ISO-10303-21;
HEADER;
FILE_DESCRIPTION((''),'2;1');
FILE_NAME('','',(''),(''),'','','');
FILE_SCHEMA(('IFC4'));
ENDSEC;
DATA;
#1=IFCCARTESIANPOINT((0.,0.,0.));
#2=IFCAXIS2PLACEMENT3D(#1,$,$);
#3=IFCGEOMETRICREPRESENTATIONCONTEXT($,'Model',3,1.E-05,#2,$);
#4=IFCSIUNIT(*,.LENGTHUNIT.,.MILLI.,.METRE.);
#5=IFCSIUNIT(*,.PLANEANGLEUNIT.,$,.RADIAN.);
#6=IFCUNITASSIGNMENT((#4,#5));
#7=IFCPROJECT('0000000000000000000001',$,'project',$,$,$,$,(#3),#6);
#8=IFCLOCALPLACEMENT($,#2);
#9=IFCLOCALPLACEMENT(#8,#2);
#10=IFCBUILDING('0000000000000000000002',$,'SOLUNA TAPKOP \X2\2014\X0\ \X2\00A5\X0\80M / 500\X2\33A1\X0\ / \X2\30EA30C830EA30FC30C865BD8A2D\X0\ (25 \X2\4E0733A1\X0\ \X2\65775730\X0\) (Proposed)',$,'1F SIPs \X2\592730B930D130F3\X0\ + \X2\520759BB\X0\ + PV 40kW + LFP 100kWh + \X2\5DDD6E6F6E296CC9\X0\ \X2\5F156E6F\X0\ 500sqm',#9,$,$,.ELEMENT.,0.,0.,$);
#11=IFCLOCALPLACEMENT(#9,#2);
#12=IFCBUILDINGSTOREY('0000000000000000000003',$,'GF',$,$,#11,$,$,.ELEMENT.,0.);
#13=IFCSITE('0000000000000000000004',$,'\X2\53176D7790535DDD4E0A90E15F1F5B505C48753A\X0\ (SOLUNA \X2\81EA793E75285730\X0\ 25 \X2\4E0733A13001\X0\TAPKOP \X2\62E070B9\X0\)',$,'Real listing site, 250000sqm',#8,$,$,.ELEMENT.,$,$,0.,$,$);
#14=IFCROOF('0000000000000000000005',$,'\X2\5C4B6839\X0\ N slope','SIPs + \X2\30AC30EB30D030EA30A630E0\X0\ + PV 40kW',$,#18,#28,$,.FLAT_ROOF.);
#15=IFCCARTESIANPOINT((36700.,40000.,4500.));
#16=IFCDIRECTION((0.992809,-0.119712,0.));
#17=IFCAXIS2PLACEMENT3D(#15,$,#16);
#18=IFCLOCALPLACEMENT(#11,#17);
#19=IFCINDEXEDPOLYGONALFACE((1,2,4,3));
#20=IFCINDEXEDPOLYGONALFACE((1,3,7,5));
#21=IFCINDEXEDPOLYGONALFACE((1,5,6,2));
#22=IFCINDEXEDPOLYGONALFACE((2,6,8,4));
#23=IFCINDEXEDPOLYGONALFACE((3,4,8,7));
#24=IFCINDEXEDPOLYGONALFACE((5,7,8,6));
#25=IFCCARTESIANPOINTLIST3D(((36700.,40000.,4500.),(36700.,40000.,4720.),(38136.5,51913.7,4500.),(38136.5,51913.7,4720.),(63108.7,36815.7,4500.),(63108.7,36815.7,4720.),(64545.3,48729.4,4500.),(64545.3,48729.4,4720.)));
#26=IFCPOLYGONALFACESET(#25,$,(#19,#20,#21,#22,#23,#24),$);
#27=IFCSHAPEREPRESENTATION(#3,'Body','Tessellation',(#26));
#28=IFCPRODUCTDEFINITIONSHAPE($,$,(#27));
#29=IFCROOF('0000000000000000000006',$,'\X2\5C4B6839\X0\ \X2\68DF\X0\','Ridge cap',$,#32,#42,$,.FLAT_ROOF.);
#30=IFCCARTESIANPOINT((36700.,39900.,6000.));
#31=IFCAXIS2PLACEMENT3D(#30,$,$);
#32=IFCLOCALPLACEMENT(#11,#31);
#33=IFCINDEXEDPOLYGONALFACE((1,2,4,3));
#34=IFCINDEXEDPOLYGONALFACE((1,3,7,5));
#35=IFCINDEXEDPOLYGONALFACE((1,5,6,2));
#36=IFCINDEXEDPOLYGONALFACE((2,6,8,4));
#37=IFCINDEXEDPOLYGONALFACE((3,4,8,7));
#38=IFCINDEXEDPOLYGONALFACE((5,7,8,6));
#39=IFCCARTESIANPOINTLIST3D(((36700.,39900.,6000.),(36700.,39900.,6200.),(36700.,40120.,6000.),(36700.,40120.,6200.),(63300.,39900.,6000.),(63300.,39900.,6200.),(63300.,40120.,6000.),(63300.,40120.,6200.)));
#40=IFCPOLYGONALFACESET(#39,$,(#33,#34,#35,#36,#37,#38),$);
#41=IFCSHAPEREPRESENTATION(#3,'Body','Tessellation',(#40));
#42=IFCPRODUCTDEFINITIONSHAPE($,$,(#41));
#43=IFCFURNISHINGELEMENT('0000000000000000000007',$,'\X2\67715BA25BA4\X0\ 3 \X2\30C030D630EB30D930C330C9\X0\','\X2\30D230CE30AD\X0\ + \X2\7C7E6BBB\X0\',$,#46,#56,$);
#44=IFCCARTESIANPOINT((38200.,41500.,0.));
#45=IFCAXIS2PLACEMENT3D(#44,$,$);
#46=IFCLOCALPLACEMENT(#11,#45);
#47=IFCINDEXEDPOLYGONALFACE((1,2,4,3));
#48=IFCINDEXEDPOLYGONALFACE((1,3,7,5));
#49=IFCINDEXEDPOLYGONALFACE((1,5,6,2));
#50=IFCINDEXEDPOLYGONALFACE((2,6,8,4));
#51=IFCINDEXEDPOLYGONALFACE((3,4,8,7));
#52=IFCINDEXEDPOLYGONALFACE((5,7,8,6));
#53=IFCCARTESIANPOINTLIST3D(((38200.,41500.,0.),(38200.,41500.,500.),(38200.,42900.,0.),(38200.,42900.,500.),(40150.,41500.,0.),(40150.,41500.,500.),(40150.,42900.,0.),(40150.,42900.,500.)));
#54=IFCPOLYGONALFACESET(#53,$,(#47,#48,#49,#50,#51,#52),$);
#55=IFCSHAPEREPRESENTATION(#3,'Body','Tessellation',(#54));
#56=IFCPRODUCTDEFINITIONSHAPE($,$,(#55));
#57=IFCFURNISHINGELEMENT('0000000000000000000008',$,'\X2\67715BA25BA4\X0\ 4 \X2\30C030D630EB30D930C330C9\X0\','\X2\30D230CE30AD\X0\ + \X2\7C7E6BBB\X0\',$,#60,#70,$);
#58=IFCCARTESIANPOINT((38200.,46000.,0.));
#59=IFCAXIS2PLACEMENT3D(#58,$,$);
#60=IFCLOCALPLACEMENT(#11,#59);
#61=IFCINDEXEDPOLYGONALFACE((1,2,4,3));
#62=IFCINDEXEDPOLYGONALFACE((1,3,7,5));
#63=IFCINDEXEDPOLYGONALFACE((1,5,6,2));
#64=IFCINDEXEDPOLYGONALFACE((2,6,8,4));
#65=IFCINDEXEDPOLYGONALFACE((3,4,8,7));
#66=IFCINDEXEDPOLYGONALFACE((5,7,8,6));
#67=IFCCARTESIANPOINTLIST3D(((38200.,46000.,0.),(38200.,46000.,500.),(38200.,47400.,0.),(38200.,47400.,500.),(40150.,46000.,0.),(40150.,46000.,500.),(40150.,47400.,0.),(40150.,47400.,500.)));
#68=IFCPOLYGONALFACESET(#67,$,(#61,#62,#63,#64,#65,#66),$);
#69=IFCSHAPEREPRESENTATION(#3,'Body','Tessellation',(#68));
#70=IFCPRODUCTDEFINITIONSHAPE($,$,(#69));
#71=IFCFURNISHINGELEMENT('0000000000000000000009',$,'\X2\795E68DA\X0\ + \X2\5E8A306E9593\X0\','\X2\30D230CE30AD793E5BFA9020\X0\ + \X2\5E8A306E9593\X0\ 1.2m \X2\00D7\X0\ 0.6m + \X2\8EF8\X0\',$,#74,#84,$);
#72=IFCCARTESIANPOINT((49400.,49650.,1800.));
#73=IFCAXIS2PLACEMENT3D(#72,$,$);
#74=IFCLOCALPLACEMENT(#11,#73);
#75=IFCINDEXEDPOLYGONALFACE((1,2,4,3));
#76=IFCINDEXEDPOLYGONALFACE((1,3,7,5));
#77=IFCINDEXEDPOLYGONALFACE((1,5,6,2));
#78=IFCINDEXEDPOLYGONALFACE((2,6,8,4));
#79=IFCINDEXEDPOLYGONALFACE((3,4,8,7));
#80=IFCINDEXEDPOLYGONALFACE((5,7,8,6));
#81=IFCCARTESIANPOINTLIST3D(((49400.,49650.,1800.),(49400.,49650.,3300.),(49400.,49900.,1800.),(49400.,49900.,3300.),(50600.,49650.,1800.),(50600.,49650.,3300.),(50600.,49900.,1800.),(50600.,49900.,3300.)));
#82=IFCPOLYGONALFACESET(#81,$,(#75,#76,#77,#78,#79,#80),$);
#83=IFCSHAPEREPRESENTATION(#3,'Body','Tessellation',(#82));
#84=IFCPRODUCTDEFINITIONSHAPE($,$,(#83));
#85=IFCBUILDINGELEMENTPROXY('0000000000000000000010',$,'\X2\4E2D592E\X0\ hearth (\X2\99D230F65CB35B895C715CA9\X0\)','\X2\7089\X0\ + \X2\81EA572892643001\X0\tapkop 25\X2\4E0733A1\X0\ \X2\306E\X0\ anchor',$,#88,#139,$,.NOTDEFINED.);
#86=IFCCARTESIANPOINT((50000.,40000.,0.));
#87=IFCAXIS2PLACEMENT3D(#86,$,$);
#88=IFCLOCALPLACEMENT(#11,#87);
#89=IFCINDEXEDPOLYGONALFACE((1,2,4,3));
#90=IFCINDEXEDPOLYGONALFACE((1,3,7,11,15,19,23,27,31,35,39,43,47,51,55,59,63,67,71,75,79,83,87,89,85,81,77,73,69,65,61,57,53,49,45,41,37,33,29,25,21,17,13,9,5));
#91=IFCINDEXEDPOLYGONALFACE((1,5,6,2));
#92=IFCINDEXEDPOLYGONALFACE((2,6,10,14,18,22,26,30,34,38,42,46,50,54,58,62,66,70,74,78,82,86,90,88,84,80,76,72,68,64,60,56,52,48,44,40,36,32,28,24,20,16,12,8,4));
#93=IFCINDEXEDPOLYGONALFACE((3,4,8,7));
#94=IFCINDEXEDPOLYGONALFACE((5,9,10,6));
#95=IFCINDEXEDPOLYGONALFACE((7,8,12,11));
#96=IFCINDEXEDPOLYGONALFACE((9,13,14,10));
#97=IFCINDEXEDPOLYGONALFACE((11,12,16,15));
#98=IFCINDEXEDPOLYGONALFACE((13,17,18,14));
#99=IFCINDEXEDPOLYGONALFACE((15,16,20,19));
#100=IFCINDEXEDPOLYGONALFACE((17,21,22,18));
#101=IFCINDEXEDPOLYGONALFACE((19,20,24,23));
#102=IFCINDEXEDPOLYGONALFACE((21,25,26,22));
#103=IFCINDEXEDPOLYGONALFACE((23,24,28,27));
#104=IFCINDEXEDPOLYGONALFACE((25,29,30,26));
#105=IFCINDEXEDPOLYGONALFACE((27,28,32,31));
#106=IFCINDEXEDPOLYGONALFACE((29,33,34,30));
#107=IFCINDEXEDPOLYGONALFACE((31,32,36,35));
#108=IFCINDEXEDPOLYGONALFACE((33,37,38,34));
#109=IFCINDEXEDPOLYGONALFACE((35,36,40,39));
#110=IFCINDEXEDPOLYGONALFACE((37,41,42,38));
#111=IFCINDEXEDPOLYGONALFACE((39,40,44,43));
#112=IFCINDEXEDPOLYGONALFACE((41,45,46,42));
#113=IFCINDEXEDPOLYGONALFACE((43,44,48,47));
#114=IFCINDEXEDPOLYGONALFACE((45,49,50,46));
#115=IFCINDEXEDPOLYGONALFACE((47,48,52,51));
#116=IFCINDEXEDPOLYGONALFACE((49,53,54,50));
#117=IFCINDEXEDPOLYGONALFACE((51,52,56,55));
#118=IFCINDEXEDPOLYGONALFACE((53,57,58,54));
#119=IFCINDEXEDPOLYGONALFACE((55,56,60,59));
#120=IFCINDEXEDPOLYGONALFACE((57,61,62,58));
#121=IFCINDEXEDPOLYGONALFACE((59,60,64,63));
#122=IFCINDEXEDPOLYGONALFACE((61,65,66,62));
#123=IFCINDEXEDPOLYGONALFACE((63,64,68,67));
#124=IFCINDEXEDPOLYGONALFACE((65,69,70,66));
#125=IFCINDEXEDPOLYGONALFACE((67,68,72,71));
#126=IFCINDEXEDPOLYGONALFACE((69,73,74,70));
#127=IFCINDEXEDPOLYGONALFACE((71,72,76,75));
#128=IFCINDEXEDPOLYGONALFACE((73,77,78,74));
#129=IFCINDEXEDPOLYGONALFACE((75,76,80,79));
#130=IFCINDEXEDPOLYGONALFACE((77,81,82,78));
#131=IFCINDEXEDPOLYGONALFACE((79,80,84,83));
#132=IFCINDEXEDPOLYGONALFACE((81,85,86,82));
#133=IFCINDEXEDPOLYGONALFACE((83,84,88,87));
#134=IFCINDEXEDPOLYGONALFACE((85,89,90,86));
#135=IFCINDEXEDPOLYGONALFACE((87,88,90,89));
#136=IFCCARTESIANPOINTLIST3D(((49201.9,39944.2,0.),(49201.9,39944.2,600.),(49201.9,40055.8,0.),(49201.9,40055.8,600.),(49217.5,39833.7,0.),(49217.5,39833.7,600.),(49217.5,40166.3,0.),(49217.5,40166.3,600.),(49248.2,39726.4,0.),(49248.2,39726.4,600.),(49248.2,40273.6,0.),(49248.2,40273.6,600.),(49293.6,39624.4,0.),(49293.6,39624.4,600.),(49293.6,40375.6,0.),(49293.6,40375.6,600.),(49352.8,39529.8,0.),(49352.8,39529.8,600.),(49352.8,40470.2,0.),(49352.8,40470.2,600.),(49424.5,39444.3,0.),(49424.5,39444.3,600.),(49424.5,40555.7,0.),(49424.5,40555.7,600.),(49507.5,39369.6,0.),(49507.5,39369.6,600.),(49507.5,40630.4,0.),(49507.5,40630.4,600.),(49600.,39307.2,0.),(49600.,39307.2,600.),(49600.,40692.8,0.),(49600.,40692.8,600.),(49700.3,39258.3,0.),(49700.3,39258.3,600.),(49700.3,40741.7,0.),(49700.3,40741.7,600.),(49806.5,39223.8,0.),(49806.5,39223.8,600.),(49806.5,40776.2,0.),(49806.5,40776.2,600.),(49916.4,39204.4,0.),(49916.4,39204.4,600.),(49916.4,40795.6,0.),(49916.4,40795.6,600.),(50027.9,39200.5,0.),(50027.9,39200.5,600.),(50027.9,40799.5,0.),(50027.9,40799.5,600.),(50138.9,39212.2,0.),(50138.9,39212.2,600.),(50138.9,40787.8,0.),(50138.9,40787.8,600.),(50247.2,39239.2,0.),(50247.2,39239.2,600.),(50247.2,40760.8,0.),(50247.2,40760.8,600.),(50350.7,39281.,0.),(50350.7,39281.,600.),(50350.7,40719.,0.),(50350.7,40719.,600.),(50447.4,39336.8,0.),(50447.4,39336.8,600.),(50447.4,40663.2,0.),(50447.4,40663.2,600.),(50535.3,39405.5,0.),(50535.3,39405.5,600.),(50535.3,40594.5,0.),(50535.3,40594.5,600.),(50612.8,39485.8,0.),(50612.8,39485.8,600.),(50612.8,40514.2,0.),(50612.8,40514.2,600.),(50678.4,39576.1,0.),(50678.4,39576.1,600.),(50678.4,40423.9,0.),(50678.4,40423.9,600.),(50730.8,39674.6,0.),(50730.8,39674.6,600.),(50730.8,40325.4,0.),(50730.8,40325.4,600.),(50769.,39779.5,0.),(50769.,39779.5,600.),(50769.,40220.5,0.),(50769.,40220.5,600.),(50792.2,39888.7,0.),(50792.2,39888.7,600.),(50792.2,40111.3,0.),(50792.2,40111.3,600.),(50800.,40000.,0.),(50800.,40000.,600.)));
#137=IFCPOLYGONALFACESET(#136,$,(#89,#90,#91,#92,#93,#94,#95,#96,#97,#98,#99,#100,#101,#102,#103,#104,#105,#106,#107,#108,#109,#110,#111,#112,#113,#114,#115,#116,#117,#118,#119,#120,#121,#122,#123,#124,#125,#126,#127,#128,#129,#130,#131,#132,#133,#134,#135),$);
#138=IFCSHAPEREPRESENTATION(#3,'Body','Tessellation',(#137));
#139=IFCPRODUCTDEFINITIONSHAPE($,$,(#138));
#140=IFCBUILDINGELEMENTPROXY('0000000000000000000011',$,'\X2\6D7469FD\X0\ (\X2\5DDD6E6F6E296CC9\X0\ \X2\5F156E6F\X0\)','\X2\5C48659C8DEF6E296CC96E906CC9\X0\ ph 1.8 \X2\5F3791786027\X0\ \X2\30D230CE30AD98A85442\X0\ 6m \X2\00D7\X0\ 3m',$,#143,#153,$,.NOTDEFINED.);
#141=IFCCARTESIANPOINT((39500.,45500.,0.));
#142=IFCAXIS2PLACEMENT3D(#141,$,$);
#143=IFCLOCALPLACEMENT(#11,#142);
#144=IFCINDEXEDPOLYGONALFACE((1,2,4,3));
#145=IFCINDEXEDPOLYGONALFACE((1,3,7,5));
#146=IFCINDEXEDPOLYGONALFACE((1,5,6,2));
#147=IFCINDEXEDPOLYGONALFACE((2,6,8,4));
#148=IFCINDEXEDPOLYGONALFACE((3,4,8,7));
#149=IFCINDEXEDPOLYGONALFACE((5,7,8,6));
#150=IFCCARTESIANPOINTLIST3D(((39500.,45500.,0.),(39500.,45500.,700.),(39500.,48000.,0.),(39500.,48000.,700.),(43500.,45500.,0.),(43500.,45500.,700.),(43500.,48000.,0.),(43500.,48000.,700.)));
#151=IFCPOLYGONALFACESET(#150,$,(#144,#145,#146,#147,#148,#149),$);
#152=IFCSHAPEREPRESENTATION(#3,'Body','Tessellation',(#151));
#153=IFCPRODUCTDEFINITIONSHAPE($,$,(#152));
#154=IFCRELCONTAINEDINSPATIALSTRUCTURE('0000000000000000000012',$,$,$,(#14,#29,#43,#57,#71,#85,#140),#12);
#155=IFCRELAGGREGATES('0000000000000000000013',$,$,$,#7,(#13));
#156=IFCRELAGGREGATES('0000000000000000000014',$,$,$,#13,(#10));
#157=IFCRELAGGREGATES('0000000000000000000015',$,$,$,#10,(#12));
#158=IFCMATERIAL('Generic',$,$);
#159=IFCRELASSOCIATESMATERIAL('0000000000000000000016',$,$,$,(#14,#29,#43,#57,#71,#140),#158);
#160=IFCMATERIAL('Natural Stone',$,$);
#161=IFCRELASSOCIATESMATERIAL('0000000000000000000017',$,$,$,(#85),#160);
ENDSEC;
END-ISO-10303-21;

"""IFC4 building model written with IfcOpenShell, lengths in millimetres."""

from ifc_helpers import new_model, si_unit, frame, frame_2d, origin, origin_2d, place, context, project, spatial, rectangle, circle, extrude, material, element, save


model = new_model("IFC4")

# Units and contexts
model_context = context("Model", 3, precision=1e-05, world=origin())
ifc_project = project(units=[si_unit("LENGTHUNIT", "METRE", prefix="MILLI"), si_unit("PLANEANGLEUNIT", "RADIAN")], contexts=[model_context])

# Site, building, storey
site_placement = place(None, origin())
site = spatial("IfcSite", under=ifc_project, at=site_placement, Name="北海道川上郡弟子屈町 (SOLUNA 自社用地 25 万㎡、TAPKOP 拠点)", ObjectType="Real listing site, 250000sqm", CompositionType="ELEMENT", RefElevation=0.0)
building_placement = place(site_placement, origin())
building = spatial("IfcBuilding", under=site, at=building_placement, Name="SOLUNA TAPKOP — ¥80M / 500㎡ / リトリート施設 (25 万㎡ 敷地) (Proposed)", ObjectType="1F SIPs 大スパン + 切妻 + PV 40kW + LFP 100kWh + 川湯温泉 引湯 500sqm", CompositionType="ELEMENT", ElevationOfRefHeight=0.0, ElevationOfTerrain=0.0)
storey_placement = place(building_placement, origin())
storey = spatial("IfcBuildingStorey", under=building, at=storey_placement, Name="GF", CompositionType="ELEMENT", Elevation=0.0)

# Shared definitions
ifc_material_1 = material(Name="Generic")

# Roofs
roof_1_placement = place(storey_placement, frame((36700.0, 40000.0, 4500.0), x_axis=(0.992809, -0.119712, 0.0)))
element("IfcRoof", 1, at=roof_1_placement, inside=storey, material=ifc_material_1, Name="屋根 N slope", Description="SIPs + ガルバリウム + PV 40kW", PredefinedType="FLAT_ROOF", context=model_context, shape_type="SweptSolid", body=[
    extrude(rectangle(XDim=26600.0, YDim=12000.0, at=frame_2d((13300.0, 6000.0))), frame((36700.0, 40000.0, 4500.0), x_axis=(0.992809, -0.119712, 0.0)), (0.0, 0.0, 1.0), 220.0),
])
roof_2_placement = place(storey_placement, frame((36700.0, 39900.0, 6000.0)))
element("IfcRoof", 2, at=roof_2_placement, inside=storey, material=ifc_material_1, Name="屋根 棟", Description="Ridge cap", PredefinedType="FLAT_ROOF", context=model_context, shape_type="SweptSolid", body=[
    extrude(rectangle(XDim=26600.0, YDim=220.0, at=frame_2d((13300.0, 110.0))), frame((36700.0, 39900.0, 6000.0)), (0.0, 0.0, 1.0), 200.0),
])

# Furnishing elements
furnishing_1_placement = place(storey_placement, frame((38200.0, 41500.0, 0.0)))
element("IfcFurnishingElement", 3, at=furnishing_1_placement, inside=storey, material=ifc_material_1, Name="東客室 3 ダブルベッド", Description="ヒノキ + 籾殻", context=model_context, shape_type="SweptSolid", body=[
    extrude(rectangle(XDim=1950.0, YDim=1400.0, at=frame_2d((975.0, 700.0))), frame((38200.0, 41500.0, 0.0)), (0.0, 0.0, 1.0), 500.0),
])
furnishing_2_placement = place(storey_placement, frame((38200.0, 46000.0, 0.0)))
element("IfcFurnishingElement", 4, at=furnishing_2_placement, inside=storey, material=ifc_material_1, Name="東客室 4 ダブルベッド", Description="ヒノキ + 籾殻", context=model_context, shape_type="SweptSolid", body=[
    extrude(rectangle(XDim=1950.0, YDim=1400.0, at=frame_2d((975.0, 700.0))), frame((38200.0, 46000.0, 0.0)), (0.0, 0.0, 1.0), 500.0),
])
furnishing_3_placement = place(storey_placement, frame((49400.0, 49650.0, 1800.0)))
element("IfcFurnishingElement", 5, at=furnishing_3_placement, inside=storey, material=ifc_material_1, Name="神棚 + 床の間", Description="ヒノキ社寺造 + 床の間 1.2m × 0.6m + 軸", context=model_context, shape_type="SweptSolid", body=[
    extrude(rectangle(XDim=1200.0, YDim=250.0, at=frame_2d((600.0, 125.0))), frame((49400.0, 49650.0, 1800.0)), (0.0, 0.0, 1.0), 1500.0),
])

# Building element proxies
ifc_material_2 = material(Name="Natural Stone")
proxy_1_placement = place(storey_placement, frame((50000.0, 40000.0, 0.0)))
element("IfcBuildingElementProxy", 6, at=proxy_1_placement, inside=storey, material=ifc_material_2, Name="中央 hearth (駒ヶ岳安山岩)", Description="炉 + 自在鉤、tapkop 25万㎡ の anchor", PredefinedType="NOTDEFINED", context=model_context, shape_type="SweptSolid", body=[
    extrude(circle(Radius=800.0, at=origin_2d()), frame((50000.0, 40000.0, 0.0)), (0.0, 0.0, 1.0), 600.0),
])
proxy_2_placement = place(storey_placement, frame((39500.0, 45500.0, 0.0)))
element("IfcBuildingElementProxy", 7, at=proxy_2_placement, inside=storey, material=ifc_material_1, Name="浴槽 (川湯温泉 引湯)", Description="屈斜路温泉源泉 ph 1.8 強酸性 ヒノキ風呂 6m × 3m", PredefinedType="NOTDEFINED", context=model_context, shape_type="SweptSolid", body=[
    extrude(rectangle(XDim=4000.0, YDim=2500.0, at=frame_2d((2000.0, 1250.0))), frame((39500.0, 45500.0, 0.0)), (0.0, 0.0, 1.0), 700.0),
])

save(model, "model.ifc")
